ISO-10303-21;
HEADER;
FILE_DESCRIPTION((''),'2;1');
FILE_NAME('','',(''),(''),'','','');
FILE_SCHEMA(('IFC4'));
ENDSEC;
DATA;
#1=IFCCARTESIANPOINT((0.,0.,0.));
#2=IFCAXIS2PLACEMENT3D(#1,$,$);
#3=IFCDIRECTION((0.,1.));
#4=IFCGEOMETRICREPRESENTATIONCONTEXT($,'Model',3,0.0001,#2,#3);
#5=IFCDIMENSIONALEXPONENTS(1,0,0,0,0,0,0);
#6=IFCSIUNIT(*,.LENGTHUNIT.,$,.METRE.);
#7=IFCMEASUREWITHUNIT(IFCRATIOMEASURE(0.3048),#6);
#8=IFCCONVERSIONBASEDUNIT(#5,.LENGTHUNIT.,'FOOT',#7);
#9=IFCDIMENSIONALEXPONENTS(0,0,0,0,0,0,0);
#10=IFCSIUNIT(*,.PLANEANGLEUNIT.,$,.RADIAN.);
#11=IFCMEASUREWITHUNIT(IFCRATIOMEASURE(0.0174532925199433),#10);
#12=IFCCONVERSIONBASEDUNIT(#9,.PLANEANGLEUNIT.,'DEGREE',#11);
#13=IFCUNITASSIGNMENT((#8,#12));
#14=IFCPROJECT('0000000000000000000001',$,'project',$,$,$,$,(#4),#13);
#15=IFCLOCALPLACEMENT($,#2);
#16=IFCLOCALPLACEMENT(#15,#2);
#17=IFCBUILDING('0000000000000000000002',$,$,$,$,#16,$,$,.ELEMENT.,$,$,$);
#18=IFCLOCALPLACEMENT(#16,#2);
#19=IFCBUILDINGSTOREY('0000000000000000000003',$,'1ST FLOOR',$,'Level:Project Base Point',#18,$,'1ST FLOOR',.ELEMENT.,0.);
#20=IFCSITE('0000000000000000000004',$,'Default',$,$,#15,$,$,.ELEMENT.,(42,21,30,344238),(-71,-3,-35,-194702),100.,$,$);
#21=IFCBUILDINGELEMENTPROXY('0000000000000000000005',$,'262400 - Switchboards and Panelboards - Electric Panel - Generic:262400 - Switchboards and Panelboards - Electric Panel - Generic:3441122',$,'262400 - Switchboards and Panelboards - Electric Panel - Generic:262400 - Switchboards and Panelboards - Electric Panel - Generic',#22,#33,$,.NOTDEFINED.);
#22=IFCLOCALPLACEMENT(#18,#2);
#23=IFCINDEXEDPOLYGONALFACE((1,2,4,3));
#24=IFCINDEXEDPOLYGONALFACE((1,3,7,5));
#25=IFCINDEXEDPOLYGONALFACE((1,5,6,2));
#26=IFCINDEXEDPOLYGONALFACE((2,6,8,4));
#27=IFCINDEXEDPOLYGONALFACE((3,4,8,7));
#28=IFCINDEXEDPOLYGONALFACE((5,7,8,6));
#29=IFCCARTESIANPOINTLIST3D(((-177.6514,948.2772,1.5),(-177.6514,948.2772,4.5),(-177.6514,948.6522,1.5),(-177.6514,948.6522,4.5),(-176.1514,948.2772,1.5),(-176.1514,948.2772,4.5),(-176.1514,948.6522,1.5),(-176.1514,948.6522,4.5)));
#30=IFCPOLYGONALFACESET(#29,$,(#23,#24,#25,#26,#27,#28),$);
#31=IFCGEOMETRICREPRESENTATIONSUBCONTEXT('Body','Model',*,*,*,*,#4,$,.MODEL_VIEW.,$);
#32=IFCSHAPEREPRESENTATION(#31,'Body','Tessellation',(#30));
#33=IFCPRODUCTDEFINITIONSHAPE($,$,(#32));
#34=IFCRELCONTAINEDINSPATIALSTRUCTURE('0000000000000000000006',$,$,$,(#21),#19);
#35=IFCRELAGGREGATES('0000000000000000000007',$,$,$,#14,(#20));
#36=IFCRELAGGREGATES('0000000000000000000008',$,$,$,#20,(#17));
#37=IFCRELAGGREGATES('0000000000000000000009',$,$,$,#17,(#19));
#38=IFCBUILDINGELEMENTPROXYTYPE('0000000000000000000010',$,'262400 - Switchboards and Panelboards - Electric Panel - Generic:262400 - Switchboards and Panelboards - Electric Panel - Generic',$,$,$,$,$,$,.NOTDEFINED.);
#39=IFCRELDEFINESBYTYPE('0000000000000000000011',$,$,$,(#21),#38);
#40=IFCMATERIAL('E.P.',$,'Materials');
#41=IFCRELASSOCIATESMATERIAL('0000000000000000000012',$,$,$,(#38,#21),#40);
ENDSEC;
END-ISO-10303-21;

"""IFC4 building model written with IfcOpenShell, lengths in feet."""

from ifc_helpers import new_model, entity, si_unit, converted_unit, direction, frame, origin, origin_2d_with_axis, place, context, subcontext, project, spatial, rectangle, extrude, source, transform, mapped, material, type_object, type_shapes, element, save


model = new_model("IFC4")

# Units and contexts
model_context = context("Model", 3, precision=0.0001, world=origin(), true_north=direction((0.0, 1.0)))
body_context = subcontext(model_context, "Body", "Model", "MODEL_VIEW")
ifc_project = project(units=[converted_unit("LENGTHUNIT", "FOOT", entity("IfcRatioMeasure", 0.3048), si_unit("LENGTHUNIT", "METRE"), dimensions=[1, 0, 0, 0, 0, 0, 0]), converted_unit("PLANEANGLEUNIT", "DEGREE", entity("IfcRatioMeasure", 0.0174532925199433), si_unit("PLANEANGLEUNIT", "RADIAN"), dimensions=[0, 0, 0, 0, 0, 0, 0])], contexts=[model_context])

# Site, building, storey
site_placement = place(None, origin())
site = spatial("IfcSite", under=ifc_project, at=site_placement, Name="Default", CompositionType="ELEMENT", RefLatitude=(42, 21, 30, 344238), RefLongitude=(-71, -3, -35, -194702), RefElevation=100.0)
building_placement = place(site_placement, origin())
building = spatial("IfcBuilding", under=site, at=building_placement, CompositionType="ELEMENT")
storey_placement = place(building_placement, origin())
storey = spatial("IfcBuildingStorey", under=building, at=storey_placement, Name="1ST FLOOR", ObjectType="Level:Project Base Point", LongName="1ST FLOOR", CompositionType="ELEMENT", Elevation=0.0)

# Building element proxy
ifc_material_1 = material(Name="E.P.", Category="Materials")
building_element_proxy_type_1 = type_object("IfcBuildingElementProxyType", Name="262400 - Switchboards and Panelboards - Electric Panel - Generic:262400 - Switchboards and Panelboards - Electric Panel - Generic", PredefinedType="NOTDEFINED", material=ifc_material_1)
shared_shape_1 = source(origin(), body_context, "Body", "SweptSolid", [
    extrude(rectangle(XDim=0.375, YDim=1.5, at=origin_2d_with_axis()), frame((0.75, 0.1875, 0.0), z_axis=(0.0, 0.0, 1.0), x_axis=(0.0, 1.0, 0.0)), (0.0, 0.0, 1.0), 3.0),
])
type_shapes(building_element_proxy_type_1, [shared_shape_1])
proxy_1_placement = place(storey_placement, frame((-177.6514, 948.2772, 1.5)))
element("IfcBuildingElementProxy", 1, at=proxy_1_placement, inside=storey, type_object=building_element_proxy_type_1, material=ifc_material_1, Name="262400 - Switchboards and Panelboards - Electric Panel - Generic:262400 - Switchboards and Panelboards - Electric Panel - Generic:3441122", ObjectType="262400 - Switchboards and Panelboards - Electric Panel - Generic:262400 - Switchboards and Panelboards - Electric Panel - Generic", PredefinedType="NOTDEFINED", context=body_context, shape_type="MappedRepresentation", body=[
    mapped(shared_shape_1, transform((0.0, 0.0, 0.0), scale=1.0)),
])

save(model, "model.ifc")
